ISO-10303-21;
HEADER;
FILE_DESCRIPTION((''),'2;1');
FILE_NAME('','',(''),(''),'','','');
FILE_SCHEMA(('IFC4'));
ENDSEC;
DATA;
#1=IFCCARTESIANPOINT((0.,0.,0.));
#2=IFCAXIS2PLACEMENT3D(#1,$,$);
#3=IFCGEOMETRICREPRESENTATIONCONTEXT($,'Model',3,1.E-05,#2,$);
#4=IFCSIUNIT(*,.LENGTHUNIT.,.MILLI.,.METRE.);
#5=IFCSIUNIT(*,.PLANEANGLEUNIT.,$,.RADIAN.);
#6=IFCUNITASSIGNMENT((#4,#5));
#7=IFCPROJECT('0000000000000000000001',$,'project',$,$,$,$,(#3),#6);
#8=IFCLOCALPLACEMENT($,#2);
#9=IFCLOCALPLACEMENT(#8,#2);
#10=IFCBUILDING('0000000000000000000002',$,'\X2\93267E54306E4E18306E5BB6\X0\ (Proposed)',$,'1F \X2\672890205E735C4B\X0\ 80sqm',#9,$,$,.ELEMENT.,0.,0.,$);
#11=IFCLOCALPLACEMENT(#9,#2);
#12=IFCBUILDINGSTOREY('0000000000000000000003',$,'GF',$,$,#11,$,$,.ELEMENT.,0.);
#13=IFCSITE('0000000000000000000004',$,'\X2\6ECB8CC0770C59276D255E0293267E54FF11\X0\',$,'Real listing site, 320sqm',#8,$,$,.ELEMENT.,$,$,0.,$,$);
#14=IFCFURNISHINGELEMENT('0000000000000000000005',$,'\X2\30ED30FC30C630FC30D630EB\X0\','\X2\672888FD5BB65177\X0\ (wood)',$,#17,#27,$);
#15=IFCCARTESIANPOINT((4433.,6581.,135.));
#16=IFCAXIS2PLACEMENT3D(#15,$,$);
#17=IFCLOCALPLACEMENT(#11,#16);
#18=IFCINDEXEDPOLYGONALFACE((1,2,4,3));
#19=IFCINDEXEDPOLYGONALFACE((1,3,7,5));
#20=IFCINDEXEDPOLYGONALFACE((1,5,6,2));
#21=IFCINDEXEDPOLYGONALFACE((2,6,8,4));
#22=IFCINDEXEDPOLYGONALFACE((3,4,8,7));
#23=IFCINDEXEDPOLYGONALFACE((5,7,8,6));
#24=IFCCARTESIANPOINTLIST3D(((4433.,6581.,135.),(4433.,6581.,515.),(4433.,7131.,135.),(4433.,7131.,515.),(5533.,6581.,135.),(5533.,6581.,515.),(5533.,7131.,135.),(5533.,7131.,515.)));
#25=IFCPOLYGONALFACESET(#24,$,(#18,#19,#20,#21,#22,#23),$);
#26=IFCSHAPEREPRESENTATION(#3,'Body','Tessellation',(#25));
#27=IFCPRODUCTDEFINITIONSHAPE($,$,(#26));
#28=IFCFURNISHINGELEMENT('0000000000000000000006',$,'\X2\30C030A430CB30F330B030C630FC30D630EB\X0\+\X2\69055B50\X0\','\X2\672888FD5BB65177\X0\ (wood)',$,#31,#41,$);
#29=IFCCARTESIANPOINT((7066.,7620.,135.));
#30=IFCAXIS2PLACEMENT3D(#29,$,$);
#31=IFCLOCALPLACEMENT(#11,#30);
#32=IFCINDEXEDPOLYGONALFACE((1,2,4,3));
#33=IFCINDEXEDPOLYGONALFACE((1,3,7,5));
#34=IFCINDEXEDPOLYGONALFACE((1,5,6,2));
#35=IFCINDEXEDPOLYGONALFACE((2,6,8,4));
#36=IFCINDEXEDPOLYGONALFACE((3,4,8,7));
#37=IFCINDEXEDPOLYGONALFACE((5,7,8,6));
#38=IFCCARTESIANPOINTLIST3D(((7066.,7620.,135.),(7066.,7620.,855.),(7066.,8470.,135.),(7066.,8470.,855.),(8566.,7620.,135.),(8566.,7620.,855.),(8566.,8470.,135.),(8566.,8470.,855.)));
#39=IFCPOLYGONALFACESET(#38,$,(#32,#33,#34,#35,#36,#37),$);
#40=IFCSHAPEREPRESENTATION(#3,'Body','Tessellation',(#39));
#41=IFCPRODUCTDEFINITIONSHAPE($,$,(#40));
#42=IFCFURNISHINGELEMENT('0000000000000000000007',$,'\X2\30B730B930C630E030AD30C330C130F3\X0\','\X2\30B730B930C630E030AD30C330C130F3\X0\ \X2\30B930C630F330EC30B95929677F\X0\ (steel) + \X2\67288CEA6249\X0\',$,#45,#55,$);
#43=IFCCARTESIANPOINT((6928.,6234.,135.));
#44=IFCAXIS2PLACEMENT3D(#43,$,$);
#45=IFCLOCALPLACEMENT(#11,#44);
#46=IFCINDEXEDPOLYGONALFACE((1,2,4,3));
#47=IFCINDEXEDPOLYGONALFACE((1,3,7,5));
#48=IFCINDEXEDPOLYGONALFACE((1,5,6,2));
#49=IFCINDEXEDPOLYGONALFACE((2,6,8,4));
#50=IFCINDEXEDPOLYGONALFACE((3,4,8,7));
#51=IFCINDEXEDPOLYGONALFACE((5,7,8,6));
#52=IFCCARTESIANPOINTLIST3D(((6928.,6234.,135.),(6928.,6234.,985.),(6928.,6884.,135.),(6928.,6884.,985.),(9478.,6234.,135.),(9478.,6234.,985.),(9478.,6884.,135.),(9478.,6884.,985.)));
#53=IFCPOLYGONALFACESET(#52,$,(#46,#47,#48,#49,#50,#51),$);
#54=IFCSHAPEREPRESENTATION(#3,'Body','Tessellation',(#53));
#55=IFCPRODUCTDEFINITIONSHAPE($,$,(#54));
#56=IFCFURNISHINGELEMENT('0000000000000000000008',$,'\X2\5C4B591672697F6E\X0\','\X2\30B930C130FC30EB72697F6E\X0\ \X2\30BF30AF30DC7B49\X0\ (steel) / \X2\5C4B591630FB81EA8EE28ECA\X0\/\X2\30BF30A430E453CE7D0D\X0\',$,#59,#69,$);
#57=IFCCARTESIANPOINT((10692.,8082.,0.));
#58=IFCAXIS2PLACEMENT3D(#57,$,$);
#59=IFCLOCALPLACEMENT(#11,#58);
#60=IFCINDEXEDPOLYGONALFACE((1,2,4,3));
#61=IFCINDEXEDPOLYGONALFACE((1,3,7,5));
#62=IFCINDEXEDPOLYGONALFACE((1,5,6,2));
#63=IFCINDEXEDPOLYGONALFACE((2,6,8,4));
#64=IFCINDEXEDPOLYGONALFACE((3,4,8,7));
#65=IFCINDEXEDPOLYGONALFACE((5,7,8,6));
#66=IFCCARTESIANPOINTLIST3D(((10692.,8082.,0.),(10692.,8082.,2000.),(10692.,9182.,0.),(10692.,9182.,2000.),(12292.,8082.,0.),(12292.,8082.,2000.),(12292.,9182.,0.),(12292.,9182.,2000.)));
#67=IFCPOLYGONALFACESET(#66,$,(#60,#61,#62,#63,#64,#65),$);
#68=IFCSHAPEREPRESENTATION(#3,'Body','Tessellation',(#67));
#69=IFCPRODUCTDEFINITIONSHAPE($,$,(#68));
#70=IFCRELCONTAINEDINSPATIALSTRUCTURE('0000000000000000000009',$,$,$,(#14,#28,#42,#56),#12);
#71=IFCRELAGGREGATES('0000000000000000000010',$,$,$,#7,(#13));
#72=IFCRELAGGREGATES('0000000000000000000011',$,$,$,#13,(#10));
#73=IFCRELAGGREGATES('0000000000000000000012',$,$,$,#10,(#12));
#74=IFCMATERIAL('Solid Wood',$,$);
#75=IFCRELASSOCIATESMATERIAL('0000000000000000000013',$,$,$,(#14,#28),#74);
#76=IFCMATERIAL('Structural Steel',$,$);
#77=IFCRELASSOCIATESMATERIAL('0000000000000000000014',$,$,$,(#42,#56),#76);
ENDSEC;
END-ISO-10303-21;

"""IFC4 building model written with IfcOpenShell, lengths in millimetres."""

from ifc_helpers import new_model, si_unit, frame, frame_2d, origin, place, context, project, spatial, rectangle, extrude, material, element, save


model = new_model("IFC4")

# Units and contexts
model_context = context("Model", 3, precision=1e-05, world=origin())
ifc_project = project(units=[si_unit("LENGTHUNIT", "METRE", prefix="MILLI"), si_unit("PLANEANGLEUNIT", "RADIAN")], contexts=[model_context])

# Site, building, storey
site_placement = place(None, origin())
site = spatial("IfcSite", under=ifc_project, at=site_placement, Name="滋賀県大津市錦織１", ObjectType="Real listing site, 320sqm", CompositionType="ELEMENT", RefElevation=0.0)
building_placement = place(site_placement, origin())
building = spatial("IfcBuilding", under=site, at=building_placement, Name="錦織の丘の家 (Proposed)", ObjectType="1F 木造平屋 80sqm", CompositionType="ELEMENT", ElevationOfRefHeight=0.0, ElevationOfTerrain=0.0)
storey_placement = place(building_placement, origin())
storey = spatial("IfcBuildingStorey", under=building, at=storey_placement, Name="GF", CompositionType="ELEMENT", Elevation=0.0)

# Shared definitions
ifc_material_1 = material(Name="Solid Wood")

# Shared definitions
ifc_material_2 = material(Name="Structural Steel")

# Furnishing elements
furnishing_1_placement = place(storey_placement, frame((4433.0, 6581.0, 135.0)))
element("IfcFurnishingElement", 1, at=furnishing_1_placement, inside=storey, material=ifc_material_1, Name="ローテーブル", Description="木製家具 (wood)", context=model_context, shape_type="SweptSolid", body=[
    extrude(rectangle(XDim=1100.0, YDim=550.0, at=frame_2d((550.0, 275.0))), frame((4433.0, 6581.0, 135.0)), (0.0, 0.0, 1.0), 380.0),
])
furnishing_2_placement = place(storey_placement, frame((7066.0, 7620.0, 135.0)))
element("IfcFurnishingElement", 2, at=furnishing_2_placement, inside=storey, material=ifc_material_1, Name="ダイニングテーブル+椅子", Description="木製家具 (wood)", context=model_context, shape_type="SweptSolid", body=[
    extrude(rectangle(XDim=1500.0, YDim=850.0, at=frame_2d((750.0, 425.0))), frame((7066.0, 7620.0, 135.0)), (0.0, 0.0, 1.0), 720.0),
])
furnishing_3_placement = place(storey_placement, frame((6928.0, 6234.0, 135.0)))
element("IfcFurnishingElement", 3, at=furnishing_3_placement, inside=storey, material=ifc_material_2, Name="システムキッチン", Description="システムキッチン ステンレス天板 (steel) + 木質扉", context=model_context, shape_type="SweptSolid", body=[
    extrude(rectangle(XDim=2550.0, YDim=650.0, at=frame_2d((1275.0, 325.0))), frame((6928.0, 6234.0, 135.0)), (0.0, 0.0, 1.0), 850.0),
])
furnishing_4_placement = place(storey_placement, frame((10692.0, 8082.0, 0.0)))
element("IfcFurnishingElement", 4, at=furnishing_4_placement, inside=storey, material=ifc_material_2, Name="屋外物置", Description="スチール物置 タクボ等 (steel) / 屋外・自転車/タイヤ収納", context=model_context, shape_type="SweptSolid", body=[
    extrude(rectangle(XDim=1600.0, YDim=1100.0, at=frame_2d((800.0, 550.0))), frame((10692.0, 8082.0, 0.0)), (0.0, 0.0, 1.0), 2000.0),
])

save(model, "model.ifc")
